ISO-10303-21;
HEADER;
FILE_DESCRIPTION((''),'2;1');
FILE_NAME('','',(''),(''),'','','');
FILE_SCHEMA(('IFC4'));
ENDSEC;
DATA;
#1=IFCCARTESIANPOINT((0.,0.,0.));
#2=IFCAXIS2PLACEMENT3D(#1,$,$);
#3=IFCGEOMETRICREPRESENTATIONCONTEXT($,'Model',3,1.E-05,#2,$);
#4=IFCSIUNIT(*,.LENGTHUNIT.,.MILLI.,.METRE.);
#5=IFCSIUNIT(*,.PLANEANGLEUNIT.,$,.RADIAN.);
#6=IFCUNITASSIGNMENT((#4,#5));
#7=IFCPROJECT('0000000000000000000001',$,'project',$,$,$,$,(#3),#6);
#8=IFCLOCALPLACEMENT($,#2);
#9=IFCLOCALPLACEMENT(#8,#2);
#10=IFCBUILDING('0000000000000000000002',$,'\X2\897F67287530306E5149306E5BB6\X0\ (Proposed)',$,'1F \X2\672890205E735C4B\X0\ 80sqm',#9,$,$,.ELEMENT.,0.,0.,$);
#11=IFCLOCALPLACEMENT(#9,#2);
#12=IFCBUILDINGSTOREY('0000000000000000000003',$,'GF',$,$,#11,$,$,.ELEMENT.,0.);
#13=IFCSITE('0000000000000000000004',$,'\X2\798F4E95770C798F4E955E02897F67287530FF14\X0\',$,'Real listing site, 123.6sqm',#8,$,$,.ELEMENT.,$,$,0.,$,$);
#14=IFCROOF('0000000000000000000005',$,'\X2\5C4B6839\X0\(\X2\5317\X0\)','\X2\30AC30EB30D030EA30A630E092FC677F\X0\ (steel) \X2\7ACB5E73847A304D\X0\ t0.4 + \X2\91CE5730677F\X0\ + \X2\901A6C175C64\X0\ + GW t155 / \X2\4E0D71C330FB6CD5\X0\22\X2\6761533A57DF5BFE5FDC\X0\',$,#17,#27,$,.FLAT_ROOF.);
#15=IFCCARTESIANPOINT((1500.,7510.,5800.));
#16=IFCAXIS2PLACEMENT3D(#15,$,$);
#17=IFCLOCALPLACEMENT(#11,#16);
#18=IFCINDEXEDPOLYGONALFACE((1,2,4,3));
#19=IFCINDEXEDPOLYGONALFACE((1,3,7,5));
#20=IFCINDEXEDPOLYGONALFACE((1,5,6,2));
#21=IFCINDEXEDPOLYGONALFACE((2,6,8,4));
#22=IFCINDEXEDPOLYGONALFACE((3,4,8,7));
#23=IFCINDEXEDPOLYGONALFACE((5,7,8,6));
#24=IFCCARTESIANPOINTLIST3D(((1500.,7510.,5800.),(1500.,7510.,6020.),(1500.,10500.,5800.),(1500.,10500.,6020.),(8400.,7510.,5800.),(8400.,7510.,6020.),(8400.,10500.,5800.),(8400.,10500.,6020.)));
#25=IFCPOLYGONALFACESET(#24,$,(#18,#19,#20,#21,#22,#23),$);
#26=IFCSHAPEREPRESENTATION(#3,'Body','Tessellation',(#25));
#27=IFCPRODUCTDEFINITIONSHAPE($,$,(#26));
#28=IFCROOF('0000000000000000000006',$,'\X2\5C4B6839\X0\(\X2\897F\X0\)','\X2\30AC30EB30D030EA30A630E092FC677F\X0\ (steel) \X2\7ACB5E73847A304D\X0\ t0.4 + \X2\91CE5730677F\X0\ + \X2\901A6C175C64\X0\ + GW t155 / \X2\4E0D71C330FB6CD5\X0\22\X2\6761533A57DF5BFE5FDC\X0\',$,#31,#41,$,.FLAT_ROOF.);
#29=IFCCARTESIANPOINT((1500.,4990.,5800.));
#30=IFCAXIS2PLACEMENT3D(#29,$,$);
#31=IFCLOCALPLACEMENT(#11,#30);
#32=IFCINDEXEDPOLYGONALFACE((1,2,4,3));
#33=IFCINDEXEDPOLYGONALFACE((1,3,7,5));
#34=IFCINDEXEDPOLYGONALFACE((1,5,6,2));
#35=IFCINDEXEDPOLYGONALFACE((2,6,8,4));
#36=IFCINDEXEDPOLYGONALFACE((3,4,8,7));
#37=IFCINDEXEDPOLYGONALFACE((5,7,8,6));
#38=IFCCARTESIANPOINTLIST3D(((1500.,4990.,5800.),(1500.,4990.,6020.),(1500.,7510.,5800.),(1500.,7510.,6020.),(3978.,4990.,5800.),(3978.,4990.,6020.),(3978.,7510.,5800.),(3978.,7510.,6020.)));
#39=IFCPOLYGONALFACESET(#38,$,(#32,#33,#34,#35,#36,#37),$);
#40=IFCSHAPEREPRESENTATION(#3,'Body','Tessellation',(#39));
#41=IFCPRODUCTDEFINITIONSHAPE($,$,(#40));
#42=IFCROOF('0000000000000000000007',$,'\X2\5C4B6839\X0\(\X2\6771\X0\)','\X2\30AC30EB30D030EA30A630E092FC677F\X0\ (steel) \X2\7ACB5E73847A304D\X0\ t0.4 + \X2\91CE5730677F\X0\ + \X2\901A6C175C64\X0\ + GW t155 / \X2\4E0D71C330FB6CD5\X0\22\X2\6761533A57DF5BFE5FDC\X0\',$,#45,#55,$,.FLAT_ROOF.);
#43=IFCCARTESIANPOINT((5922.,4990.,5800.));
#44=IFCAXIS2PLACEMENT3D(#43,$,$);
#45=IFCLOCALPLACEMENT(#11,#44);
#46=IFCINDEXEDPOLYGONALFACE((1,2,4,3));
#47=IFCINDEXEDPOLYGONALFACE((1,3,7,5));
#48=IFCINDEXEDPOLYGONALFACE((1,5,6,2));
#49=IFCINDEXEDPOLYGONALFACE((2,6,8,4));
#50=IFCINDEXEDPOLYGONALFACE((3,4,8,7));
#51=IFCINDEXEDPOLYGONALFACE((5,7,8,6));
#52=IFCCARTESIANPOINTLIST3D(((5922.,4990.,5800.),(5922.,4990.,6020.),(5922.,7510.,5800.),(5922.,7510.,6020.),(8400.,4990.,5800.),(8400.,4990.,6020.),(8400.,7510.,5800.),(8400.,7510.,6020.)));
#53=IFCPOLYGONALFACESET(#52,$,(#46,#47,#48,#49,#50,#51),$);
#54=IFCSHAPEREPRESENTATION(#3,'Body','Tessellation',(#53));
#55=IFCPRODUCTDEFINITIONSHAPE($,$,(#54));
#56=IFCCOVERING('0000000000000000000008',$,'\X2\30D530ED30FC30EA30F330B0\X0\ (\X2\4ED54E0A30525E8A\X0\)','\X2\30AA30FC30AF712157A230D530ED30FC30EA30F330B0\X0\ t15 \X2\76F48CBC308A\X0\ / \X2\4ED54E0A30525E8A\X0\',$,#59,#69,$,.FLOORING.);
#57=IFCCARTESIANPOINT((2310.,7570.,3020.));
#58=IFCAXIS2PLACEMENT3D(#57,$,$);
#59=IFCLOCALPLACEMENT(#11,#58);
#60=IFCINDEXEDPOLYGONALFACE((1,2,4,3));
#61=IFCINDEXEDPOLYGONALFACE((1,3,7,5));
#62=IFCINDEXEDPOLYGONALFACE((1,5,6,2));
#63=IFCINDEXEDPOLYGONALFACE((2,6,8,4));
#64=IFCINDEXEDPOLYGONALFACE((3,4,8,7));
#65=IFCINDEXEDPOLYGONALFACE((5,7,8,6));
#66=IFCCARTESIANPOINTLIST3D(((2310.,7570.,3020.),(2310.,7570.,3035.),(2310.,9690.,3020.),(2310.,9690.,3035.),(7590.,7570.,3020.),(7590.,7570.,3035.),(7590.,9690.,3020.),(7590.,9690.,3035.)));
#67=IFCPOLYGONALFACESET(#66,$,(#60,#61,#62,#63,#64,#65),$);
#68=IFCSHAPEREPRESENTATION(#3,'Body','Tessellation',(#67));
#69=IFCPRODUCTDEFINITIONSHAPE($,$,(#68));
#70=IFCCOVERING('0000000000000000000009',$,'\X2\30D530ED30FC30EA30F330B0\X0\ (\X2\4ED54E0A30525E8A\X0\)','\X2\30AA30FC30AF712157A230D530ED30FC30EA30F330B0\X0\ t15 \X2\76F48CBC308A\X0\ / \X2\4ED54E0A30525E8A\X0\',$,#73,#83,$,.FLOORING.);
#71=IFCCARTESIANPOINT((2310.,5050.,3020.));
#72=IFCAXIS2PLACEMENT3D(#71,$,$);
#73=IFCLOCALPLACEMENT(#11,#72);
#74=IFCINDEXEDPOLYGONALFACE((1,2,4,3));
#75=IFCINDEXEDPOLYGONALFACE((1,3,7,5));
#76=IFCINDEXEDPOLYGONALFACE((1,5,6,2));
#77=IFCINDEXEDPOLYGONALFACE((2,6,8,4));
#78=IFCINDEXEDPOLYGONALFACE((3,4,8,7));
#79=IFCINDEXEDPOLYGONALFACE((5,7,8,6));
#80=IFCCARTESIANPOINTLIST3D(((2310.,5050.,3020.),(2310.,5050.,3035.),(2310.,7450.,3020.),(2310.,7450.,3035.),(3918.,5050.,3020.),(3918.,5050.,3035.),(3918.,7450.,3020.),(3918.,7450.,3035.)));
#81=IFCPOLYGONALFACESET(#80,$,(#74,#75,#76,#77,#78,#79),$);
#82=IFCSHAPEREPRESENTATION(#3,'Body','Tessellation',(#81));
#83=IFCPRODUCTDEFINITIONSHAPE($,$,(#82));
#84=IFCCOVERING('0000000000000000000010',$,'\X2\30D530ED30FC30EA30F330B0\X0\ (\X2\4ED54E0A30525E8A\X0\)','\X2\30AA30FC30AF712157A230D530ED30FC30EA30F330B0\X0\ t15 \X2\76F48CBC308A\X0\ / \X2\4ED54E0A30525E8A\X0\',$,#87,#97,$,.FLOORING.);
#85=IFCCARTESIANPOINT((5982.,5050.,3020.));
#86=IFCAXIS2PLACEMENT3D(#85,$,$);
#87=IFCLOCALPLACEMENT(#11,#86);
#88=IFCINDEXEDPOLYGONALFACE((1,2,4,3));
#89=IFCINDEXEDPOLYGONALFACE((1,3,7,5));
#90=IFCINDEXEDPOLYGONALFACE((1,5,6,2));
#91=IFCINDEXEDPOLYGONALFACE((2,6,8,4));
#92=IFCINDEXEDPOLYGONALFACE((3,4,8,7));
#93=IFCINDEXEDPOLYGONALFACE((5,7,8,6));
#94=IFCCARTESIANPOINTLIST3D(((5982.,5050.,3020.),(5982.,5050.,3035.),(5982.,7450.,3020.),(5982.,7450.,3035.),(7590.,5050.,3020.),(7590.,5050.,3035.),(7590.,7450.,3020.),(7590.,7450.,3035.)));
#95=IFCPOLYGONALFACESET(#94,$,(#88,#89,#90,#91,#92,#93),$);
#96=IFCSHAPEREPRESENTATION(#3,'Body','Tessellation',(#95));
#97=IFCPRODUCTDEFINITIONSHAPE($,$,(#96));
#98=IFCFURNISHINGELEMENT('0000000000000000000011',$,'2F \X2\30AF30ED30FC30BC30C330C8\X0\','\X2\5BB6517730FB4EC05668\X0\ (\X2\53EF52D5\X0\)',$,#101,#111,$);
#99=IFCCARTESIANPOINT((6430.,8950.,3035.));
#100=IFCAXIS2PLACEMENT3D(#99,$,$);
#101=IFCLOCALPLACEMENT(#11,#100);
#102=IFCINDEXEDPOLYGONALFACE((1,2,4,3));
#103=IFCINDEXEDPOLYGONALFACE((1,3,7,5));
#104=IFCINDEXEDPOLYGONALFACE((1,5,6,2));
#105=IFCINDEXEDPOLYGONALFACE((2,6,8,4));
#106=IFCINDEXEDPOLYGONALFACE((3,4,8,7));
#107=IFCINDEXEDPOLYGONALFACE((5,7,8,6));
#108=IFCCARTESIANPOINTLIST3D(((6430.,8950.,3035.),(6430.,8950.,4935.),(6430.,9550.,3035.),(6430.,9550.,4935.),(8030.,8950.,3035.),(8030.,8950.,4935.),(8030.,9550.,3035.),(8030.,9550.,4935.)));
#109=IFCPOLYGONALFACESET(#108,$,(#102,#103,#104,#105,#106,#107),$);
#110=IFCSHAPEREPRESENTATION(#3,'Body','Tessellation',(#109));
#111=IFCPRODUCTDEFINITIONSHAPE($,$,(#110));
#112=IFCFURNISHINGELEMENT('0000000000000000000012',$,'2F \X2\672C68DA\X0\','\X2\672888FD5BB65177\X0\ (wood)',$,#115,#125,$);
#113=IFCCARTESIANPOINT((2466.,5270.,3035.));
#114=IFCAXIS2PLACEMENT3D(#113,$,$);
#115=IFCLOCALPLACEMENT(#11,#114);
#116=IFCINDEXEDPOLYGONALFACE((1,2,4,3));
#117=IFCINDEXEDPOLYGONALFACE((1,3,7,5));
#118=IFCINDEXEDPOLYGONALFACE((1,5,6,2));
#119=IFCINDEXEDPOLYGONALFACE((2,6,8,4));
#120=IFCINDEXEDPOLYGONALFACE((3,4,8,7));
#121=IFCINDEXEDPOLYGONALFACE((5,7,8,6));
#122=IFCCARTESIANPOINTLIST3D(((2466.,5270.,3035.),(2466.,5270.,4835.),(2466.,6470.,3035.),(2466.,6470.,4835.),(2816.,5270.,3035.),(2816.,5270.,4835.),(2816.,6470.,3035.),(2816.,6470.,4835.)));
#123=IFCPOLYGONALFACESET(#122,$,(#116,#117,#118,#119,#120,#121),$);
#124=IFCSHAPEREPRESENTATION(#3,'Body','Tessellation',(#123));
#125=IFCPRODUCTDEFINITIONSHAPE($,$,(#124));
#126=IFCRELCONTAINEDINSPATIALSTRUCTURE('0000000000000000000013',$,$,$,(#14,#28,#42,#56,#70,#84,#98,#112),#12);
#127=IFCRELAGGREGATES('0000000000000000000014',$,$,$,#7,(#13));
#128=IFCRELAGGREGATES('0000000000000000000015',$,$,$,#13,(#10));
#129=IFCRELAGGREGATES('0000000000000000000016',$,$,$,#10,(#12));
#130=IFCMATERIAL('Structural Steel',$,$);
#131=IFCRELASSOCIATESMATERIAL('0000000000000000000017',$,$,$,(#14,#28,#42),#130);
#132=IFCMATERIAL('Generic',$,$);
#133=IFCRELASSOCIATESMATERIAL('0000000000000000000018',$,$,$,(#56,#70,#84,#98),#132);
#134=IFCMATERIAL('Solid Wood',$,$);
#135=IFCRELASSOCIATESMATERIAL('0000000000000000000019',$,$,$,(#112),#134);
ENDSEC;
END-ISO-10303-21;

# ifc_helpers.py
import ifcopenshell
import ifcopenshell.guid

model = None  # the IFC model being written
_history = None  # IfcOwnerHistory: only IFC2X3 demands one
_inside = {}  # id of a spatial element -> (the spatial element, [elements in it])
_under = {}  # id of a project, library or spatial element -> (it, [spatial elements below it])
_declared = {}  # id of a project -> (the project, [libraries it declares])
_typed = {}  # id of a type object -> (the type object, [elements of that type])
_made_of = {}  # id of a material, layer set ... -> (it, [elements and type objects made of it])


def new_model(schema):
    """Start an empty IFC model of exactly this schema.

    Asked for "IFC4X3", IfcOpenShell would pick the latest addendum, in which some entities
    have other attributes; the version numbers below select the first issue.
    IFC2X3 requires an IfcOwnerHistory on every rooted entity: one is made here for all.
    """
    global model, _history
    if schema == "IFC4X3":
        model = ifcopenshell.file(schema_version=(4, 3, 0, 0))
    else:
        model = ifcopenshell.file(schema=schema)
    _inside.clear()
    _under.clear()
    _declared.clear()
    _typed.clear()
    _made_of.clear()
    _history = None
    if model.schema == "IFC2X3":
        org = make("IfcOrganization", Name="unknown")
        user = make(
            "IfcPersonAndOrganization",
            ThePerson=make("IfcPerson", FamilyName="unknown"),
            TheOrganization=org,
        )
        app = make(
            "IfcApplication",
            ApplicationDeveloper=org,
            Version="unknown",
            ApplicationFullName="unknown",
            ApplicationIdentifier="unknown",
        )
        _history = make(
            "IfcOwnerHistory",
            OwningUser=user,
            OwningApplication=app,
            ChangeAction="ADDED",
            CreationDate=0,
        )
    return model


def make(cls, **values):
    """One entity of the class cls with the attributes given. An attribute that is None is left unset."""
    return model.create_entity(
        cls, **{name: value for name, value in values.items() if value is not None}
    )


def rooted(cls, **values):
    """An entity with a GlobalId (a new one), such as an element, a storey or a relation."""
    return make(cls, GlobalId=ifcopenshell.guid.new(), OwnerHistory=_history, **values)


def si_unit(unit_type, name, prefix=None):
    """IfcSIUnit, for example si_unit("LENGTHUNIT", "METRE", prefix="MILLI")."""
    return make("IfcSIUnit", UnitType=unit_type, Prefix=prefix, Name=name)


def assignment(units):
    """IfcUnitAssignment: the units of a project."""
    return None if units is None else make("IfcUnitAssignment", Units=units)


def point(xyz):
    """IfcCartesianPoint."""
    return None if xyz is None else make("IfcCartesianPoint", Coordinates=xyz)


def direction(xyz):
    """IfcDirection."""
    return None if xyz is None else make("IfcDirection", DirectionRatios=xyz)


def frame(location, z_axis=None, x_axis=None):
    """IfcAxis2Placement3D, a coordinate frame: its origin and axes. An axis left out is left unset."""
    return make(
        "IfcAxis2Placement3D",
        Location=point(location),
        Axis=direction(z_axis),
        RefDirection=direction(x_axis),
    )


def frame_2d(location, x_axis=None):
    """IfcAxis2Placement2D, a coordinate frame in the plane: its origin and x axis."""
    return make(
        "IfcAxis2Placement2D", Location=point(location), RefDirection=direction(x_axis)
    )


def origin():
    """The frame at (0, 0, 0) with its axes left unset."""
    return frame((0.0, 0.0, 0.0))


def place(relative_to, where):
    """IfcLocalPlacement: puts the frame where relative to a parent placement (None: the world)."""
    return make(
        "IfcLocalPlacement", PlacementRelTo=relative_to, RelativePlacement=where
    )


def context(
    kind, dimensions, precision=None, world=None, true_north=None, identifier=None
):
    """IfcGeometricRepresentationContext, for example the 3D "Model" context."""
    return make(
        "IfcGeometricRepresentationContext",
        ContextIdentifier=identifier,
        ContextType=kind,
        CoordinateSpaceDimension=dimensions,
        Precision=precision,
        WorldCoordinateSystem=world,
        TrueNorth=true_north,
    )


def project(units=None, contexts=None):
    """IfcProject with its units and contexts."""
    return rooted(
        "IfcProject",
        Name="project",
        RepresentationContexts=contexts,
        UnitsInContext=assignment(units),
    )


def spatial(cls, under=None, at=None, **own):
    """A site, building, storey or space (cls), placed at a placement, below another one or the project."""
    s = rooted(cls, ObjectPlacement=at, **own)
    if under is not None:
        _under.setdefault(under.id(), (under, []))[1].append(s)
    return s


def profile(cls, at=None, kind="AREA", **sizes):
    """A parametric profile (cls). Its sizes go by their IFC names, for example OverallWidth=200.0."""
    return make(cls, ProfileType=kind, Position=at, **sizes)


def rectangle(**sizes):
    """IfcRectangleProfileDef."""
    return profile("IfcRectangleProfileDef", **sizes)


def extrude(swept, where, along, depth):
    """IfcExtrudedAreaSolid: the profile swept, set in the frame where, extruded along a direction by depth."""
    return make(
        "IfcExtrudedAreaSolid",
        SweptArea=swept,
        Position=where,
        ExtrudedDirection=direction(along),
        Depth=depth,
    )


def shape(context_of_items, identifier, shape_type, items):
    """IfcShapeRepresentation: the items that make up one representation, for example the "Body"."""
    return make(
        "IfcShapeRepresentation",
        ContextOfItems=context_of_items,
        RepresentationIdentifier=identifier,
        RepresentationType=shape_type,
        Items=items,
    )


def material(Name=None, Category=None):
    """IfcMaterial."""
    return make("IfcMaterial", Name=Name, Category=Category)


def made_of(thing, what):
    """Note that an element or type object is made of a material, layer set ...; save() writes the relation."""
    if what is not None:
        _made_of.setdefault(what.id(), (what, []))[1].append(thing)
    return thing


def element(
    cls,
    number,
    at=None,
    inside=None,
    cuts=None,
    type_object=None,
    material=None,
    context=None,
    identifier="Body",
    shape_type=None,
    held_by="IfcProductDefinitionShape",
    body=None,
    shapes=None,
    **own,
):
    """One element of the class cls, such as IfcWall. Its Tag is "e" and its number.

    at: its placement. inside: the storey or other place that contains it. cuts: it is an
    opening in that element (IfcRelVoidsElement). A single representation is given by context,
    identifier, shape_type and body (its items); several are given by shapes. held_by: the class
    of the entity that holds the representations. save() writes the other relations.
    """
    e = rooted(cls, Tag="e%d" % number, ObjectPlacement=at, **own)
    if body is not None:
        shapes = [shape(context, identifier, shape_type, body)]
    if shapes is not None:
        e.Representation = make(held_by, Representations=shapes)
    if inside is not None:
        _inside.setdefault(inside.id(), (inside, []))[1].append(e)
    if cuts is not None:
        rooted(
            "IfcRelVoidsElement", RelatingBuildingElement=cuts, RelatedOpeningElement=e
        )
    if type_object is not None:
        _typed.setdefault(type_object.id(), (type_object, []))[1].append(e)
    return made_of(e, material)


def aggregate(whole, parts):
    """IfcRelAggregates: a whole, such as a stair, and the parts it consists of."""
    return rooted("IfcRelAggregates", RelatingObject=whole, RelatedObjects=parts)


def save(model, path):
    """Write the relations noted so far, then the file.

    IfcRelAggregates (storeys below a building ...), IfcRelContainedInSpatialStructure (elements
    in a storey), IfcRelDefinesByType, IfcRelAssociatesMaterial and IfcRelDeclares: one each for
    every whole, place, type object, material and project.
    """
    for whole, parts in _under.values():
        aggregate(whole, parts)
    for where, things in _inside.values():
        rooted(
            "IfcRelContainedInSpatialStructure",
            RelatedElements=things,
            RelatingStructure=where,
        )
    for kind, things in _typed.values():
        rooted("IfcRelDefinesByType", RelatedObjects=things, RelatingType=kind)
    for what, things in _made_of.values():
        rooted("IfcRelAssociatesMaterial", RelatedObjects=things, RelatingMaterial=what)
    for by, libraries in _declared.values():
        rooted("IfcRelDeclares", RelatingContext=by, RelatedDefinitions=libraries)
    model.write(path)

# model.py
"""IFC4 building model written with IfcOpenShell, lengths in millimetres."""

from ifc_helpers import new_model, si_unit, frame, frame_2d, origin, place, context, project, spatial, rectangle, extrude, material, element, save


model = new_model("IFC4")

# Units and contexts
model_context = context("Model", 3, precision=1e-05, world=origin())
ifc_project = project(units=[si_unit("LENGTHUNIT", "METRE", prefix="MILLI"), si_unit("PLANEANGLEUNIT", "RADIAN")], contexts=[model_context])

# Site, building, storey
site_placement = place(None, origin())
site = spatial("IfcSite", under=ifc_project, at=site_placement, Name="福井県福井市西木田４", ObjectType="Real listing site, 123.6sqm", CompositionType="ELEMENT", RefElevation=0.0)
building_placement = place(site_placement, origin())
building = spatial("IfcBuilding", under=site, at=building_placement, Name="西木田の光の家 (Proposed)", ObjectType="1F 木造平屋 80sqm", CompositionType="ELEMENT", ElevationOfRefHeight=0.0, ElevationOfTerrain=0.0)
storey_placement = place(building_placement, origin())
storey = spatial("IfcBuildingStorey", under=building, at=storey_placement, Name="GF", CompositionType="ELEMENT", Elevation=0.0)

# Shared definitions
ifc_material_1 = material(Name="Solid Wood")

# Shared definitions
ifc_material_2 = material(Name="Generic")

# Roofs
ifc_material_3 = material(Name="Structural Steel")
for number, where, name in (
    (1, (1500.0, 7510.0, 5800.0), "屋根(北)"),
):
    element("IfcRoof", number, at=place(storey_placement, frame(where)), inside=storey, material=ifc_material_3, Name=name, Description="ガルバリウム鋼板 (steel) 立平葺き t0.4 + 野地板 + 通気層 + GW t155 / 不燃・法22条区域対応", PredefinedType="FLAT_ROOF", context=model_context, shape_type="SweptSolid", body=[
        extrude(rectangle(XDim=6900.0, YDim=2990.0, at=frame_2d((3450.0, 1495.0))), frame((1500.0, 7510.0, 5800.0)), (0.0, 0.0, 1.0), 220.0),
    ])
roof_1_placement = place(storey_placement, frame((1500.0, 4990.0, 5800.0)))
element("IfcRoof", 2, at=roof_1_placement, inside=storey, material=ifc_material_3, Name="屋根(西)", Description="ガルバリウム鋼板 (steel) 立平葺き t0.4 + 野地板 + 通気層 + GW t155 / 不燃・法22条区域対応", PredefinedType="FLAT_ROOF", context=model_context, shape_type="SweptSolid", body=[
    extrude(rectangle(XDim=2478.0, YDim=2520.0, at=frame_2d((1239.0, 1260.0))), frame((1500.0, 4990.0, 5800.0)), (0.0, 0.0, 1.0), 220.0),
])
roof_2_placement = place(storey_placement, frame((5922.0, 4990.0, 5800.0)))
element("IfcRoof", 3, at=roof_2_placement, inside=storey, material=ifc_material_3, Name="屋根(東)", Description="ガルバリウム鋼板 (steel) 立平葺き t0.4 + 野地板 + 通気層 + GW t155 / 不燃・法22条区域対応", PredefinedType="FLAT_ROOF", context=model_context, shape_type="SweptSolid", body=[
    extrude(rectangle(XDim=2478.0, YDim=2520.0, at=frame_2d((1239.0, 1260.0))), frame((5922.0, 4990.0, 5800.0)), (0.0, 0.0, 1.0), 220.0),
])

# Coverings
covering_1_placement = place(storey_placement, frame((2310.0, 7570.0, 3020.0)))
element("IfcCovering", 4, at=covering_1_placement, inside=storey, material=ifc_material_2, Name="フローリング (仕上げ床)", Description="オーク無垢フローリング t15 直貼り / 仕上げ床", PredefinedType="FLOORING", context=model_context, shape_type="SweptSolid", body=[
    extrude(rectangle(XDim=5280.0, YDim=2120.0, at=frame_2d((2640.0, 1060.0))), frame((2310.0, 7570.0, 3020.0)), (0.0, 0.0, 1.0), 15.0),
])
covering_2_placement = place(storey_placement, frame((2310.0, 5050.0, 3020.0)))
element("IfcCovering", 5, at=covering_2_placement, inside=storey, material=ifc_material_2, Name="フローリング (仕上げ床)", Description="オーク無垢フローリング t15 直貼り / 仕上げ床", PredefinedType="FLOORING", context=model_context, shape_type="SweptSolid", body=[
    extrude(rectangle(XDim=1608.0, YDim=2400.0, at=frame_2d((804.0, 1200.0))), frame((2310.0, 5050.0, 3020.0)), (0.0, 0.0, 1.0), 15.0),
])
covering_3_placement = place(storey_placement, frame((5982.0, 5050.0, 3020.0)))
element("IfcCovering", 6, at=covering_3_placement, inside=storey, material=ifc_material_2, Name="フローリング (仕上げ床)", Description="オーク無垢フローリング t15 直貼り / 仕上げ床", PredefinedType="FLOORING", context=model_context, shape_type="SweptSolid", body=[
    extrude(rectangle(XDim=1608.0, YDim=2400.0, at=frame_2d((804.0, 1200.0))), frame((5982.0, 5050.0, 3020.0)), (0.0, 0.0, 1.0), 15.0),
])

# Furnishing elements
furnishing_1_placement = place(storey_placement, frame((6430.0, 8950.0, 3035.0)))
element("IfcFurnishingElement", 7, at=furnishing_1_placement, inside=storey, material=ifc_material_2, Name="2F クローゼット", Description="家具・什器 (可動)", context=model_context, shape_type="SweptSolid", body=[
    extrude(rectangle(XDim=1600.0, YDim=600.0, at=frame_2d((800.0, 300.0))), frame((6430.0, 8950.0, 3035.0)), (0.0, 0.0, 1.0), 1900.0),
])
furnishing_2_placement = place(storey_placement, frame((2466.0, 5270.0, 3035.0)))
element("IfcFurnishingElement", 8, at=furnishing_2_placement, inside=storey, material=ifc_material_1, Name="2F 本棚", Description="木製家具 (wood)", context=model_context, shape_type="SweptSolid", body=[
    extrude(rectangle(XDim=350.0, YDim=1200.0, at=frame_2d((175.0, 600.0))), frame((2466.0, 5270.0, 3035.0)), (0.0, 0.0, 1.0), 1800.0),
])

save(model, "model.ifc")
